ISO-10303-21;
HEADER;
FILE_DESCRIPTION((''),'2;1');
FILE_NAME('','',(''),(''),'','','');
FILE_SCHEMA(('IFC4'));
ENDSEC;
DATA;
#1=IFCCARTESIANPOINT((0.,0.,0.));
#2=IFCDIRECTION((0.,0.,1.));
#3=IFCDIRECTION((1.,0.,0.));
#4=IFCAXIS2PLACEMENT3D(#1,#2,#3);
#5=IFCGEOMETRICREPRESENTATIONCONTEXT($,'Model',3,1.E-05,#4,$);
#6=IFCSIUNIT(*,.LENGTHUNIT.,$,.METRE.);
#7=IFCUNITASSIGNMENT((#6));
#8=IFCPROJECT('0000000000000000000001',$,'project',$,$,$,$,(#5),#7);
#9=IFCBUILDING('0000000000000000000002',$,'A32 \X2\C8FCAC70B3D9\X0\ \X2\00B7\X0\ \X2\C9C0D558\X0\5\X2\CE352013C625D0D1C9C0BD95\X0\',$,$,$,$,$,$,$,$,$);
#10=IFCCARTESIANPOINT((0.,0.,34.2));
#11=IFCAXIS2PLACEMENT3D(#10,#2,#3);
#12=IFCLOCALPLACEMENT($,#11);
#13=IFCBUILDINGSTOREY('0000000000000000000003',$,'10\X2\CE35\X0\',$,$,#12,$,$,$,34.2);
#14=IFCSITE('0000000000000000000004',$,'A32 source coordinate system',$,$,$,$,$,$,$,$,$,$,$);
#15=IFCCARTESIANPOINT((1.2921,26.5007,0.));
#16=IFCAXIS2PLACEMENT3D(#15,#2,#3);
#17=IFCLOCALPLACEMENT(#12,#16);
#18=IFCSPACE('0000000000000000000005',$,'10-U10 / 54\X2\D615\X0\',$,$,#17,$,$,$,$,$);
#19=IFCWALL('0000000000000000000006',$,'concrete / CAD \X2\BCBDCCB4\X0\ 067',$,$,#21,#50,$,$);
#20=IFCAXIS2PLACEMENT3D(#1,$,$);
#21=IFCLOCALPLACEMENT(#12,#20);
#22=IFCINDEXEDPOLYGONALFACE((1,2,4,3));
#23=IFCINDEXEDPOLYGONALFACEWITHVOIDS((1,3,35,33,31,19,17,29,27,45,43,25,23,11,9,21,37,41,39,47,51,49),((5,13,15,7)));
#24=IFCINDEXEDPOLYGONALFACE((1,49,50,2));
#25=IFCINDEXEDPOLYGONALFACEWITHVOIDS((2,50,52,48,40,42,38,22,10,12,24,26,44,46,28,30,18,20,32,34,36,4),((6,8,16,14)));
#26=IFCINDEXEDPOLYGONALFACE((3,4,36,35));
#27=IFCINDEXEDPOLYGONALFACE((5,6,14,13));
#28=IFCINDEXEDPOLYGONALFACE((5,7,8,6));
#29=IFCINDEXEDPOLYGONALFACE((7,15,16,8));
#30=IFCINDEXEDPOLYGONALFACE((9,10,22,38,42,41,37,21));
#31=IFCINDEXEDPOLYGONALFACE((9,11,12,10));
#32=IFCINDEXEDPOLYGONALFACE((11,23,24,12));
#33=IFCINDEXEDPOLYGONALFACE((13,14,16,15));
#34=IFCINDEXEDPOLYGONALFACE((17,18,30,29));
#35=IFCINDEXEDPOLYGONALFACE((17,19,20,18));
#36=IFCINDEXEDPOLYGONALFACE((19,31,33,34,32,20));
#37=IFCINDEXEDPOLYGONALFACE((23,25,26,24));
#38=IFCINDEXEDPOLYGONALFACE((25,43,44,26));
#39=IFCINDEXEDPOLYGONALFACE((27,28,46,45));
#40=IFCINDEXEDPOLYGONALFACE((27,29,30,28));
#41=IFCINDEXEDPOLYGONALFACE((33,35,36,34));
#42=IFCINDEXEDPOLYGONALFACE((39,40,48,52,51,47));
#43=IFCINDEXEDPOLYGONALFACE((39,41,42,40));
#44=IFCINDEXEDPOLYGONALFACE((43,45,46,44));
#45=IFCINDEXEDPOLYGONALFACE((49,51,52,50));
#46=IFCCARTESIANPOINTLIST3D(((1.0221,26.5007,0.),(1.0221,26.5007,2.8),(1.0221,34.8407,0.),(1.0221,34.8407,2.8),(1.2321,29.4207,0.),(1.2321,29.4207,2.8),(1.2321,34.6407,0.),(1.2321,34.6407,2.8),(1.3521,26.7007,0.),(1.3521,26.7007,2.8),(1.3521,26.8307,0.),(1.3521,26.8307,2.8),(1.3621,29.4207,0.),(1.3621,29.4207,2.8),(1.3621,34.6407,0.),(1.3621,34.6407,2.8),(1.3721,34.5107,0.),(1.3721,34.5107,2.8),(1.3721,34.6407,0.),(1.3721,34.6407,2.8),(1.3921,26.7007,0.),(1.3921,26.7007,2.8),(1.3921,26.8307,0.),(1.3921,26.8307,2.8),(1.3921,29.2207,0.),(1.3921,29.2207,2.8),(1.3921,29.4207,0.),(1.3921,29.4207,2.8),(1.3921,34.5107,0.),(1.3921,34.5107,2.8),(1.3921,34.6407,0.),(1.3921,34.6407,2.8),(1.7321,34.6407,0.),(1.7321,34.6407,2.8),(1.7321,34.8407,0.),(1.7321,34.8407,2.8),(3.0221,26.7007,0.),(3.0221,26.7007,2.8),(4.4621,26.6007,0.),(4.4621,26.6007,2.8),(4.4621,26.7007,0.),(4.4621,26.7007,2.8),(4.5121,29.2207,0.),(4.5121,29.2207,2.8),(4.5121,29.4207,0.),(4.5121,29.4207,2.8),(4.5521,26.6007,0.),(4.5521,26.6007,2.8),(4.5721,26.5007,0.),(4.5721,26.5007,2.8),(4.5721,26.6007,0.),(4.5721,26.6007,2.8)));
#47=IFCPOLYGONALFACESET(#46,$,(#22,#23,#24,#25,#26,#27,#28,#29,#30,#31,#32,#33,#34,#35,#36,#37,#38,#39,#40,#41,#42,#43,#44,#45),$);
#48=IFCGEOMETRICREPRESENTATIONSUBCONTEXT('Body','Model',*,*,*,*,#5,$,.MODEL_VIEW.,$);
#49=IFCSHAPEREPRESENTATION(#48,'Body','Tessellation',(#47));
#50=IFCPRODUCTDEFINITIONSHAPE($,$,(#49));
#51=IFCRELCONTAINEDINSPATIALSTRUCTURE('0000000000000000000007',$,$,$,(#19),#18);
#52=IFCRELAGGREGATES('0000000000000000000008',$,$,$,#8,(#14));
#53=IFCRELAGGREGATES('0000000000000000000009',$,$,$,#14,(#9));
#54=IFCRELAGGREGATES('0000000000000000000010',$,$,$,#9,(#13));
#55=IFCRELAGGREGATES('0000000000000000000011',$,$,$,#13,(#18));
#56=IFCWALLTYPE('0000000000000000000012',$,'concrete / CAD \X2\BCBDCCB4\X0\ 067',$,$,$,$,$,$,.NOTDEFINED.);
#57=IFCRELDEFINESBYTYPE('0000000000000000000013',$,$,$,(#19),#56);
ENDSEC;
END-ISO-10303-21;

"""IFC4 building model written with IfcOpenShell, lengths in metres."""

from ifc_helpers import new_model, si_unit, frame, origin, origin_with_axes, place, context, subcontext, project, spatial, polyline, outline, extrude, source, transform, mapped, type_object, type_shapes, element, save


model = new_model("IFC4")

# Units and contexts
model_context = context("Model", 3, precision=1e-05, world=origin_with_axes())
body_context = subcontext(model_context, "Body", "Model", "MODEL_VIEW")
ifc_project = project(units=[si_unit("LENGTHUNIT", "METRE")], contexts=[model_context])

# Site, building, storey, space
site = spatial("IfcSite", under=ifc_project, Name="A32 source coordinate system")
building = spatial("IfcBuilding", under=site, Name="A32 주거동 · 지하5층–옥탑지붕")
storey_placement = place(None, frame((0.0, 0.0, 34.2), z_axis=(0.0, 0.0, 1.0), x_axis=(1.0, 0.0, 0.0)))
storey = spatial("IfcBuildingStorey", under=building, at=storey_placement, Name="10층", Elevation=34.2)
space_placement = place(storey_placement, frame((1.2921, 26.5007, 0.0), z_axis=(0.0, 0.0, 1.0), x_axis=(1.0, 0.0, 0.0)))
space = spatial("IfcSpace", under=storey, at=space_placement, Name="10-U10 / 54형")

# Wall
wall_type_1 = type_object("IfcWallType", Name="concrete / CAD 벽체 067", PredefinedType="NOTDEFINED")
shared_shape_1 = source(origin(), body_context, "Body", "SweptSolid", [
    extrude(outline(polyline([(0.1, 0.2), (1.73, 0.2), (3.17, 0.2), (3.17, 0.1), (3.26, 0.1), (3.28, 0.1), (3.28, 0.0), (-0.27, 0.0), (-0.27, 8.34), (0.44, 8.34), (0.44, 8.14), (0.1, 8.14), (0.08, 8.14), (0.08, 8.01), (0.1, 8.01), (0.1, 2.92), (3.22, 2.92), (3.22, 2.72), (0.1, 2.72), (0.1, 0.33), (0.06, 0.33), (0.06, 0.2), (0.1, 0.2)]), holes=[polyline([(-0.06, 8.14), (-0.06, 2.92), (0.07, 2.92), (0.07, 8.14), (-0.06, 8.14)])]), origin(), (0.0, 0.0, 1.0), 2.8),
])
type_shapes(wall_type_1, [shared_shape_1])
wall_1_placement = place(space_placement, origin_with_axes())
element("IfcWall", 1, at=wall_1_placement, inside=space, type_object=wall_type_1, Name="concrete / CAD 벽체 067", context=body_context, shape_type="MappedRepresentation", body=[
    mapped(shared_shape_1, transform((0.0, 0.0, 0.0), scale=1.0)),
])

save(model, "model.ifc")
